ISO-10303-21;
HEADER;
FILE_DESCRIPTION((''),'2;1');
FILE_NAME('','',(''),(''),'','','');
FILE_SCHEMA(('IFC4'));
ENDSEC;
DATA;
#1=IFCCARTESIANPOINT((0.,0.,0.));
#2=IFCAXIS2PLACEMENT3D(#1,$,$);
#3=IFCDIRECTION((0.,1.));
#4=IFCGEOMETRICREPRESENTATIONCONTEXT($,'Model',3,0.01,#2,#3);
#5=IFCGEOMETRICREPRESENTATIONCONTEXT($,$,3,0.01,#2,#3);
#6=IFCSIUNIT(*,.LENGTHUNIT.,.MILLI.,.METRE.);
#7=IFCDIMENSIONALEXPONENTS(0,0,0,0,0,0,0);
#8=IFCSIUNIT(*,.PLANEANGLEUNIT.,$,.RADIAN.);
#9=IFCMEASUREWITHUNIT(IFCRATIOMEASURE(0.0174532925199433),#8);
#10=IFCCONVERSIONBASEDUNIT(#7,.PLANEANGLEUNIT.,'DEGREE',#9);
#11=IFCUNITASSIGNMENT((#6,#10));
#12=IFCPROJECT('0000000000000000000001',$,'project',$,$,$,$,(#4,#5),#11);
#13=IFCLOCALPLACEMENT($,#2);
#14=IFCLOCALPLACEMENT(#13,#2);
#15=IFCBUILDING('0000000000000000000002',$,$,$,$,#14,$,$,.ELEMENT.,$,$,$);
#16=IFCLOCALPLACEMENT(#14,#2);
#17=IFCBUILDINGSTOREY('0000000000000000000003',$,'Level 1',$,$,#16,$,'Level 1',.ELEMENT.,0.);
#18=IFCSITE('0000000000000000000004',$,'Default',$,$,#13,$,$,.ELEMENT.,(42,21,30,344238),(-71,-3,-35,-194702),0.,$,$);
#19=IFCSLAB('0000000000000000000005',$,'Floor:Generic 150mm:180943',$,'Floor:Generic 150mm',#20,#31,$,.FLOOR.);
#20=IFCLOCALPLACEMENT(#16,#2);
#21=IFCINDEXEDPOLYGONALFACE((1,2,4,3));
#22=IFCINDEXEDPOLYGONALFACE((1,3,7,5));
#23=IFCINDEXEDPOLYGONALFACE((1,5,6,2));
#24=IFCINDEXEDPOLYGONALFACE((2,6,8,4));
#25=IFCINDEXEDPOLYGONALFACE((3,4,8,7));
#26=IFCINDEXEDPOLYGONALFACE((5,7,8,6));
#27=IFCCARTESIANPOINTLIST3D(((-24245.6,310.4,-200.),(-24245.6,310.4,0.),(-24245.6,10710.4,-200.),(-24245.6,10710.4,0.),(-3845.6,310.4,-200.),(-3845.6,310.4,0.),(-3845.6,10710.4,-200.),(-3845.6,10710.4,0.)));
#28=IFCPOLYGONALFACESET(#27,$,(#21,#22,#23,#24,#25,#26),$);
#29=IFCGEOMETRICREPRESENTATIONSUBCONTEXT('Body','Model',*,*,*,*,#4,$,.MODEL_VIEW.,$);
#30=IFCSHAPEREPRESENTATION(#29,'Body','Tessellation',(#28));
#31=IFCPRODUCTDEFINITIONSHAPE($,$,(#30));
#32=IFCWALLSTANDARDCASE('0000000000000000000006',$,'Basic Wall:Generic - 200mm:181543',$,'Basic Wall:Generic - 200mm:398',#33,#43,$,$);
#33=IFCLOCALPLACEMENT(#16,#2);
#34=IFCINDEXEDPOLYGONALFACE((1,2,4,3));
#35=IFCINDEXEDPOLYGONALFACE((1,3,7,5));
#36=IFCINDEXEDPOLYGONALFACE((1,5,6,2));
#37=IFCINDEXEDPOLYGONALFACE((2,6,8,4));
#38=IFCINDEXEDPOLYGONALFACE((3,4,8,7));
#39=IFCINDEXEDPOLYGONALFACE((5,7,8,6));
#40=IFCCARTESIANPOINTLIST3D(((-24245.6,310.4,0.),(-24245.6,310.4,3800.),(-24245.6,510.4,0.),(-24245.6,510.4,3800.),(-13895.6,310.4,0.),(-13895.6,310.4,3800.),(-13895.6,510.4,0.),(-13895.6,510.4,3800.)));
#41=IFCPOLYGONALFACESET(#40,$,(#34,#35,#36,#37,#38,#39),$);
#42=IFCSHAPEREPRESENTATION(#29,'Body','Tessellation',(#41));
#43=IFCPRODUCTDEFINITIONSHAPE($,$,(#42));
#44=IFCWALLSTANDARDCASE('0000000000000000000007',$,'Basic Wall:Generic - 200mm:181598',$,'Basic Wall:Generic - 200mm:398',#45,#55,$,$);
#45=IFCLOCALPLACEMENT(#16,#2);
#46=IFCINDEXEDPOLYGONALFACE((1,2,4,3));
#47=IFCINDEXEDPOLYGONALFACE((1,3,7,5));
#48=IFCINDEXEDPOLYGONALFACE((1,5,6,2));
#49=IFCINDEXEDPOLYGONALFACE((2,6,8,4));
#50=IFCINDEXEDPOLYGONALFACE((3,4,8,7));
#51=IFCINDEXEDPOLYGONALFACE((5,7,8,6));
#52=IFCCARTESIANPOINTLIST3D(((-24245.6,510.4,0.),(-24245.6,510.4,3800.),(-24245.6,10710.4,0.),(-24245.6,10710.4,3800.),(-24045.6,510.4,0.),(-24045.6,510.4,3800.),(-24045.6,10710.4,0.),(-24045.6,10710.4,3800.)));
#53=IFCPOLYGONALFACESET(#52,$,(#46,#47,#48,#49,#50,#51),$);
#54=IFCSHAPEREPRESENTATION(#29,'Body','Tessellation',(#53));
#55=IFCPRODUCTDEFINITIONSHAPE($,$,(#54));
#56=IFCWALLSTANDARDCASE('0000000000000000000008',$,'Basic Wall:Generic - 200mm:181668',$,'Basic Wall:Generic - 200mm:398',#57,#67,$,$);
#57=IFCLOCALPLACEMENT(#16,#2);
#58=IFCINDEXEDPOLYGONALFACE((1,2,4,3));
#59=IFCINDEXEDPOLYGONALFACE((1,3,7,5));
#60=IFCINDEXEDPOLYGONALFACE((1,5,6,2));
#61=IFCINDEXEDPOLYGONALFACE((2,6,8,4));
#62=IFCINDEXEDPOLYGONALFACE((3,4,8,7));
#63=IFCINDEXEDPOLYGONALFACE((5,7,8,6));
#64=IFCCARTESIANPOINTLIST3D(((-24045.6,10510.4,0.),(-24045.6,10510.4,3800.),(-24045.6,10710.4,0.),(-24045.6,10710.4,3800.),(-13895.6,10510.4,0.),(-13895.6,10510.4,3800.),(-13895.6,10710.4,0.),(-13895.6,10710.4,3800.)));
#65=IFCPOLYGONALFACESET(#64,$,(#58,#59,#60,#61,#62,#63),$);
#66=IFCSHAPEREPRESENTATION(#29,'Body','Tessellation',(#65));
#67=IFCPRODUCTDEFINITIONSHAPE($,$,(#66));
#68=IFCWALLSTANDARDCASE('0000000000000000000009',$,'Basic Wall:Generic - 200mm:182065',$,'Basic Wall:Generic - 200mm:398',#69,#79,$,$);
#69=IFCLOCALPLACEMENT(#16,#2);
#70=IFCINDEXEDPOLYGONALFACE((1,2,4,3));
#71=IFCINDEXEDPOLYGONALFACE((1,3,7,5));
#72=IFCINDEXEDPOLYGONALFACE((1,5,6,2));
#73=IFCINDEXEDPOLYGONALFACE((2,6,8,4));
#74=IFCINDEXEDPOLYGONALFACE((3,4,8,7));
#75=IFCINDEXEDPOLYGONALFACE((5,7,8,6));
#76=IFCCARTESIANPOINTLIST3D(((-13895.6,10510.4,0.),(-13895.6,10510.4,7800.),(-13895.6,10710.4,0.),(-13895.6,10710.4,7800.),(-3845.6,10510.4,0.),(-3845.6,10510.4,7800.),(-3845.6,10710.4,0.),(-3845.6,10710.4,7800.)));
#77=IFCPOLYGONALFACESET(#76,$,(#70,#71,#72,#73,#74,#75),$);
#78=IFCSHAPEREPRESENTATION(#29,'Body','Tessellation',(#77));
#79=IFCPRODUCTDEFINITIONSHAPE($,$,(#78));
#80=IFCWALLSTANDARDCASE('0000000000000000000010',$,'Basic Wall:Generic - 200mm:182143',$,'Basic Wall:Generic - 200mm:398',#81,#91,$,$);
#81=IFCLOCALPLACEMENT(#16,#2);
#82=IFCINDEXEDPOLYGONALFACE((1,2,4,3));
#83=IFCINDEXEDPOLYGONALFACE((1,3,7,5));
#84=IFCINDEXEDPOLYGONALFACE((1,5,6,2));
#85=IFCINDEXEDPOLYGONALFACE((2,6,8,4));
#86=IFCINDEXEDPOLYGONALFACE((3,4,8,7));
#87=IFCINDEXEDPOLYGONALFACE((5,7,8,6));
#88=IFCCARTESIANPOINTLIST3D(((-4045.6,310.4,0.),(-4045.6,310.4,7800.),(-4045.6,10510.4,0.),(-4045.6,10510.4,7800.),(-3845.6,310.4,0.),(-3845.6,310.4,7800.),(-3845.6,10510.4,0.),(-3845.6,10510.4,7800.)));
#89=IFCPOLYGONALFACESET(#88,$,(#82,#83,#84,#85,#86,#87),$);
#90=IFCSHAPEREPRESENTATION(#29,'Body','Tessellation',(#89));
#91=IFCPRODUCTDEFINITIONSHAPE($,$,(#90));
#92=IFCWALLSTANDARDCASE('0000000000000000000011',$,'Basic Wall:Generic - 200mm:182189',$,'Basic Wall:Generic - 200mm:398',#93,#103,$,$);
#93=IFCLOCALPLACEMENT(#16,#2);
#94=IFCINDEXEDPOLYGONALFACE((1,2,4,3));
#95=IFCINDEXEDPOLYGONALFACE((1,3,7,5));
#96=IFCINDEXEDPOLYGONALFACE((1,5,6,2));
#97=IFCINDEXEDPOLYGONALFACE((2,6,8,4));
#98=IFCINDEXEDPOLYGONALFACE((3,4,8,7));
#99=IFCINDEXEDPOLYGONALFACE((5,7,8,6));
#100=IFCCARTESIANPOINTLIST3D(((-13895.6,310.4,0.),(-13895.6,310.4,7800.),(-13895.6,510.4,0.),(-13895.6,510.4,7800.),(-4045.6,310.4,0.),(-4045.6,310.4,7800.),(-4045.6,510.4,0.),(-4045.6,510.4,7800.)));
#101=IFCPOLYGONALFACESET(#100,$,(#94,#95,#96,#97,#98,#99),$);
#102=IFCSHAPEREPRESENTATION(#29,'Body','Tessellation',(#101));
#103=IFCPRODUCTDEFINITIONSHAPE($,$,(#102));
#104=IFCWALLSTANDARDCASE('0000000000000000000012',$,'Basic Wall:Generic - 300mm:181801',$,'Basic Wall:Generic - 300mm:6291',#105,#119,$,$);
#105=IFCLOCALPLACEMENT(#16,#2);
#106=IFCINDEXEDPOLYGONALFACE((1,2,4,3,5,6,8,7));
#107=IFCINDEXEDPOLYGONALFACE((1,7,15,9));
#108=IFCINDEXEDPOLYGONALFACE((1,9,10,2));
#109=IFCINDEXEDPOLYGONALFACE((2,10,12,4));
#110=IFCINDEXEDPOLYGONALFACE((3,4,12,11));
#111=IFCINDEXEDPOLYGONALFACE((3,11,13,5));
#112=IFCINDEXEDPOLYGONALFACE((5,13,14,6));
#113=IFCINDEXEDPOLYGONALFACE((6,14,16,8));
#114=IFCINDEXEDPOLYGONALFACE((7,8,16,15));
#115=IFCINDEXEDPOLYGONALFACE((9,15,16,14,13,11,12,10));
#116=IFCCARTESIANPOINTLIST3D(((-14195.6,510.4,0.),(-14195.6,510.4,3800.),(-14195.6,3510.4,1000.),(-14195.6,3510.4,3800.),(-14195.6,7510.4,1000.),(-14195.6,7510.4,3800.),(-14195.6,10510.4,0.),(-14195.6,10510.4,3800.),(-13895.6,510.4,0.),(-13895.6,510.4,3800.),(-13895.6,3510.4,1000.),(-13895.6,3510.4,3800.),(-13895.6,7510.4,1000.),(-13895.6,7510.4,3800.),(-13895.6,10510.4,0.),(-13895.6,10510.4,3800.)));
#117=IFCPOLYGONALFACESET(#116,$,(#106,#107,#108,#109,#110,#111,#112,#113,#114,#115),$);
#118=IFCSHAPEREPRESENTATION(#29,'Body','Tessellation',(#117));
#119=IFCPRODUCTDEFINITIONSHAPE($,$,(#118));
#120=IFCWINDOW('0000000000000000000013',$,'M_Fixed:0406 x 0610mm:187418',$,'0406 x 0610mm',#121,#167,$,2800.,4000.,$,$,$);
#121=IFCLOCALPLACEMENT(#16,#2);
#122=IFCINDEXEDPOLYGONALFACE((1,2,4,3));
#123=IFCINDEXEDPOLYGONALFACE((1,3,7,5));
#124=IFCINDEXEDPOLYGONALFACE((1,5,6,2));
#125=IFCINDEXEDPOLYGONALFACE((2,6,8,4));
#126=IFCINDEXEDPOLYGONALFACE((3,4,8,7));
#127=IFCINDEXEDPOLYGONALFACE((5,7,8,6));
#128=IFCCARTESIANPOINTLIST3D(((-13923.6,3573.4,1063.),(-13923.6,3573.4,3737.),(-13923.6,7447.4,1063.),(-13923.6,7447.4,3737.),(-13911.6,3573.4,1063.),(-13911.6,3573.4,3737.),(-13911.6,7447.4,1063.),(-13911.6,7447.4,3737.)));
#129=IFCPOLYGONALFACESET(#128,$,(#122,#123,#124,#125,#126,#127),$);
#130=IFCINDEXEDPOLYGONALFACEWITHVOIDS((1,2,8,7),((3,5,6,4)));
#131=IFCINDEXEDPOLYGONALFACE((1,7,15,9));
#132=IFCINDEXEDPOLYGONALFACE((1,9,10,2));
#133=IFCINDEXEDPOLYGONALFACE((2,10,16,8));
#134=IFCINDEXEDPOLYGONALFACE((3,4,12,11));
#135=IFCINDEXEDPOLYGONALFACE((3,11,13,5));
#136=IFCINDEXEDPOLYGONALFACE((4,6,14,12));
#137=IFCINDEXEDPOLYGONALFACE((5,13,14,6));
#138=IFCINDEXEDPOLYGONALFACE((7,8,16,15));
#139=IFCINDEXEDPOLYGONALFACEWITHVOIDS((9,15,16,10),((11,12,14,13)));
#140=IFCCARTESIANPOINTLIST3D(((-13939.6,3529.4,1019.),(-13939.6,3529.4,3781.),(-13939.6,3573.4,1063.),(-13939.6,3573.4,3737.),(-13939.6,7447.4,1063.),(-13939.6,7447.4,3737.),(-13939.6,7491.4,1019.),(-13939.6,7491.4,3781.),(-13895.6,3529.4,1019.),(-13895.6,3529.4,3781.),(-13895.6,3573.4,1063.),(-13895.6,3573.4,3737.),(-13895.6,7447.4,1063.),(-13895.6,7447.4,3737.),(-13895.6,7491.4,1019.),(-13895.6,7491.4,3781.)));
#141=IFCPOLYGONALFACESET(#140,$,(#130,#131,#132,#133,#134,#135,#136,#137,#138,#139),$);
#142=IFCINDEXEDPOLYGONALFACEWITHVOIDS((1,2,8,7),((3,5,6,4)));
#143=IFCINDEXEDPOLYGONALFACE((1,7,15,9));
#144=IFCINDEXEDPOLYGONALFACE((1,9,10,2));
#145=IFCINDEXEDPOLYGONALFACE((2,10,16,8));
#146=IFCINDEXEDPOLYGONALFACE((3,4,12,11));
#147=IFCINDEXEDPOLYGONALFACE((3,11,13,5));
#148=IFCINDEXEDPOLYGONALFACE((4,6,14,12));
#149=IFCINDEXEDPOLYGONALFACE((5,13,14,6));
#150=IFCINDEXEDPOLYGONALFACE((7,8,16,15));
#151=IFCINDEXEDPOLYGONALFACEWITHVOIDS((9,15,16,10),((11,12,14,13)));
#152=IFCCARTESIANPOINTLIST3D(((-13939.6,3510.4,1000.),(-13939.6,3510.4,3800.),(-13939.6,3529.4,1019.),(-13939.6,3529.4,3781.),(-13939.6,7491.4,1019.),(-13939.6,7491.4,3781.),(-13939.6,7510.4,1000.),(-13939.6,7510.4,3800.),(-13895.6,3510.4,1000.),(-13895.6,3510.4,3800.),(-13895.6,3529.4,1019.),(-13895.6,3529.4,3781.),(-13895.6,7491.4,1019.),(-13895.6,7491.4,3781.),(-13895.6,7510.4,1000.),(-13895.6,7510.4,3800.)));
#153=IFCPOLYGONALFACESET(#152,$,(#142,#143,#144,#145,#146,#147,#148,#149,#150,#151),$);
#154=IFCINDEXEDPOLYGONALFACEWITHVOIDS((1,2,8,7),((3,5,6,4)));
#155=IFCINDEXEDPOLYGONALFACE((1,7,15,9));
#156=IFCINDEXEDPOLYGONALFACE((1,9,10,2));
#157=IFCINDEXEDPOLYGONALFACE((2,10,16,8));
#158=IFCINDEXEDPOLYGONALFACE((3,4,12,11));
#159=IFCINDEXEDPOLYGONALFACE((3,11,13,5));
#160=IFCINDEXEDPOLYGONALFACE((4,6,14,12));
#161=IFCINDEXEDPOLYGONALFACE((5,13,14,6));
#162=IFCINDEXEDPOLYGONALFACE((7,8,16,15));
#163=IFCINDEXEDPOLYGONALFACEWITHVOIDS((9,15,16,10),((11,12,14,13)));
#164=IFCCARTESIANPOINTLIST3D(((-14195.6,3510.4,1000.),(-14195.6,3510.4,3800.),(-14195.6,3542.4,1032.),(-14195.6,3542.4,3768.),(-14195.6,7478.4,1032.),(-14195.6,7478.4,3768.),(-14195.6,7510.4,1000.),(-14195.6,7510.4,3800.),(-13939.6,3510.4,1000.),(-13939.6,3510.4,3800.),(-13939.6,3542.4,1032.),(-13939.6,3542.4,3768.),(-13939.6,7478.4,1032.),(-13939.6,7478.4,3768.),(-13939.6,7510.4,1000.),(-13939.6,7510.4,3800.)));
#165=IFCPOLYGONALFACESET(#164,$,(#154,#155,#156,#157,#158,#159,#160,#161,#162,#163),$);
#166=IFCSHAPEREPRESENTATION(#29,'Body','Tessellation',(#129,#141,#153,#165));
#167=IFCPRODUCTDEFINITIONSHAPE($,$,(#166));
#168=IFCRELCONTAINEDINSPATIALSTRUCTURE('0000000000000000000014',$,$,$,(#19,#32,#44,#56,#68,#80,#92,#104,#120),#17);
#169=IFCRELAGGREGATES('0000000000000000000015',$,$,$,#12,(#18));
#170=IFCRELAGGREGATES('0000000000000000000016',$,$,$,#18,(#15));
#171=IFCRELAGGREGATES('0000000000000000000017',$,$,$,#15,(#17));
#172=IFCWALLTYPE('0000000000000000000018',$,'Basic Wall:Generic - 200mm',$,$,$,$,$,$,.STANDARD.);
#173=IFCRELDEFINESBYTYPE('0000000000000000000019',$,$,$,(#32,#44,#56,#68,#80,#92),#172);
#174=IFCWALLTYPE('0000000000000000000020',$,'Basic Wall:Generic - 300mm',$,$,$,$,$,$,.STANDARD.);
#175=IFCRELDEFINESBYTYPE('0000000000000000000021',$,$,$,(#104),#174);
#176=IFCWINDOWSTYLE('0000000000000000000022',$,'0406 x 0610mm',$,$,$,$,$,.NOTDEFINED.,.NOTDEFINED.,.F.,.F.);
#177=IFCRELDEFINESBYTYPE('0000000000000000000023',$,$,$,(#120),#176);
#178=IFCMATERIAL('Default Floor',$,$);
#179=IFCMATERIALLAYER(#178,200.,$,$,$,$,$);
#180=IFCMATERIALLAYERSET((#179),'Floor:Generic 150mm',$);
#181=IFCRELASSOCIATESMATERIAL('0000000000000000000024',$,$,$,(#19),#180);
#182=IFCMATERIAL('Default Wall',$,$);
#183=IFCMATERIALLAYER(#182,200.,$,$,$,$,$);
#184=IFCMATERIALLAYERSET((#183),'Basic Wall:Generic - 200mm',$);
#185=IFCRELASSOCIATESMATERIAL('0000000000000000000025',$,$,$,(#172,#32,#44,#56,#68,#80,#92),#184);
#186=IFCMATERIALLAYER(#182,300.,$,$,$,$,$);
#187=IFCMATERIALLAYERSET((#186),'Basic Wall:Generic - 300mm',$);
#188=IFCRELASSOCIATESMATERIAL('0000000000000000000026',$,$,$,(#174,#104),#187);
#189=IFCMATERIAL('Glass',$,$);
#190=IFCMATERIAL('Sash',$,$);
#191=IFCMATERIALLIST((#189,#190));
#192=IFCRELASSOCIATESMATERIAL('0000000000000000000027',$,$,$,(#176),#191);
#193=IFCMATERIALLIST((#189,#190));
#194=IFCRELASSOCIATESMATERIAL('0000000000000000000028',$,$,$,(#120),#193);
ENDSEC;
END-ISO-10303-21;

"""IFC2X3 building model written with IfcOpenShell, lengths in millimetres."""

from ifc_helpers import new_model, entity, si_unit, converted_unit, direction, frame, frame_2d, origin, origin_2d_with_axis, place, context, subcontext, project, spatial, polyline, rectangle, outline, extrude, source, transform, mapped, material, material_list, layer, layer_set, layer_usage, type_object, type_shapes, element, fill, save


model = new_model("IFC2X3")

# Units and contexts
model_context = context("Model", 3, precision=0.01, world=origin(), true_north=direction((0.0, 1.0)))
context_of_model = context(None, 3, precision=0.01, world=origin(), true_north=direction((0.0, 1.0)))
body_context = subcontext(model_context, "Body", "Model", "MODEL_VIEW")
ifc_project = project(units=[si_unit("LENGTHUNIT", "METRE", prefix="MILLI"), converted_unit("PLANEANGLEUNIT", "DEGREE", entity("IfcRatioMeasure", 0.0174532925199433), si_unit("PLANEANGLEUNIT", "RADIAN"), dimensions=[0, 0, 0, 0, 0, 0, 0])], contexts=[model_context, context_of_model])

# Site, building, storey
site_placement = place(None, origin())
site = spatial("IfcSite", under=ifc_project, at=site_placement, Name="Default", CompositionType="ELEMENT", RefLatitude=(42, 21, 30, 344238), RefLongitude=(-71, -3, -35, -194702), RefElevation=0.0)
building_placement = place(site_placement, origin())
building = spatial("IfcBuilding", under=site, at=building_placement, CompositionType="ELEMENT")
storey_placement = place(building_placement, origin())
storey = spatial("IfcBuildingStorey", under=building, at=storey_placement, Name="Level 1", LongName="Level 1", CompositionType="ELEMENT", Elevation=0.0)

# Slab
ifc_material_1 = material(Name="Default Floor")
ifc_layer_1 = layer(ifc_material_1, 200.0)
ifc_layer_set_1 = layer_set([ifc_layer_1], Name="Floor:Generic 150mm")
ifc_layer_usage_1 = layer_usage(ifc_layer_set_1, "AXIS3", "POSITIVE", 0.0)
slab_placement = place(storey_placement, origin())
element("IfcSlab", 1, at=slab_placement, inside=storey, material=ifc_layer_usage_1, Name="Floor:Generic 150mm:180943", ObjectType="Floor:Generic 150mm", PredefinedType="FLOOR", context=body_context, shape_type="SweptSolid", body=[
    extrude(rectangle(XDim=10400.0, YDim=20400.0, at=origin_2d_with_axis()), frame((-14045.6, 5510.4, 0.0), z_axis=(0.0, 0.0, -1.0), x_axis=(0.0, 1.0, 0.0)), (0.0, 0.0, 1.0), 200.0),
])

# Walls
ifc_material_2 = material(Name="Default Wall")
ifc_layer_2 = layer(ifc_material_2, 200.0)
ifc_layer_set_2 = layer_set([ifc_layer_2], Name="Basic Wall:Generic - 200mm")
ifc_layer_usage_2 = layer_usage(ifc_layer_set_2, "AXIS2", "NEGATIVE", 100.0)
wall_type_1 = type_object("IfcWallType", Name="Basic Wall:Generic - 200mm", PredefinedType="STANDARD", material=ifc_layer_set_2)
wall_1_placement = place(storey_placement, frame((-13895.6, 410.4, 0.0), z_axis=(0.0, 0.0, 1.0), x_axis=(-1.0, 0.0, 0.0)))
element("IfcWallStandardCase", 2, at=wall_1_placement, inside=storey, type_object=wall_type_1, material=ifc_layer_usage_2, Name="Basic Wall:Generic - 200mm:181543", ObjectType="Basic Wall:Generic - 200mm:398", context=body_context, shape_type="SweptSolid", body=[
    extrude(rectangle(XDim=10350.0, YDim=200.0, at=frame_2d((5175.0, 0.0), x_axis=(-1.0, 0.0))), origin(), (0.0, 0.0, 1.0), 3800.0),
])
ifc_layer_usage_3 = layer_usage(ifc_layer_set_2, "AXIS2", "NEGATIVE", 100.0)
wall_2_placement = place(storey_placement, frame((-24145.6, 510.4, 0.0), z_axis=(0.0, 0.0, 1.0), x_axis=(0.0, 1.0, 0.0)))
element("IfcWallStandardCase", 3, at=wall_2_placement, inside=storey, type_object=wall_type_1, material=ifc_layer_usage_3, Name="Basic Wall:Generic - 200mm:181598", ObjectType="Basic Wall:Generic - 200mm:398", context=body_context, shape_type="SweptSolid", body=[
    extrude(rectangle(XDim=10200.0, YDim=200.0, at=frame_2d((5100.0, 0.0), x_axis=(-1.0, 0.0))), origin(), (0.0, 0.0, 1.0), 3800.0),
])
ifc_layer_usage_4 = layer_usage(ifc_layer_set_2, "AXIS2", "NEGATIVE", 100.0)
wall_3_placement = place(storey_placement, frame((-24045.6, 10610.4, 0.0)))
element("IfcWallStandardCase", 4, at=wall_3_placement, inside=storey, type_object=wall_type_1, material=ifc_layer_usage_4, Name="Basic Wall:Generic - 200mm:181668", ObjectType="Basic Wall:Generic - 200mm:398", context=body_context, shape_type="SweptSolid", body=[
    extrude(rectangle(XDim=10150.0, YDim=200.0, at=frame_2d((5075.0, 0.0), x_axis=(-1.0, 0.0))), origin(), (0.0, 0.0, 1.0), 3800.0),
])
ifc_layer_usage_5 = layer_usage(ifc_layer_set_2, "AXIS2", "NEGATIVE", 100.0)
wall_4_placement = place(storey_placement, frame((-13895.6, 10610.4, 0.0)))
element("IfcWallStandardCase", 5, at=wall_4_placement, inside=storey, type_object=wall_type_1, material=ifc_layer_usage_5, Name="Basic Wall:Generic - 200mm:182065", ObjectType="Basic Wall:Generic - 200mm:398", context=body_context, shape_type="SweptSolid", body=[
    extrude(rectangle(XDim=10050.0, YDim=200.0, at=frame_2d((5025.0, 0.0), x_axis=(-1.0, 0.0))), origin(), (0.0, 0.0, 1.0), 7800.0),
])
ifc_layer_usage_6 = layer_usage(ifc_layer_set_2, "AXIS2", "NEGATIVE", 100.0)
wall_5_placement = place(storey_placement, frame((-3945.6, 10510.4, 0.0), z_axis=(0.0, 0.0, 1.0), x_axis=(0.0, -1.0, 0.0)))
element("IfcWallStandardCase", 6, at=wall_5_placement, inside=storey, type_object=wall_type_1, material=ifc_layer_usage_6, Name="Basic Wall:Generic - 200mm:182143", ObjectType="Basic Wall:Generic - 200mm:398", context=body_context, shape_type="SweptSolid", body=[
    extrude(rectangle(XDim=10200.0, YDim=200.0, at=frame_2d((5100.0, 0.0), x_axis=(-1.0, 0.0))), origin(), (0.0, 0.0, 1.0), 7800.0),
])
ifc_layer_usage_7 = layer_usage(ifc_layer_set_2, "AXIS2", "NEGATIVE", 100.0)
wall_6_placement = place(storey_placement, frame((-4045.6, 410.4, 0.0), z_axis=(0.0, 0.0, 1.0), x_axis=(-1.0, 0.0, 0.0)))
element("IfcWallStandardCase", 7, at=wall_6_placement, inside=storey, type_object=wall_type_1, material=ifc_layer_usage_7, Name="Basic Wall:Generic - 200mm:182189", ObjectType="Basic Wall:Generic - 200mm:398", context=body_context, shape_type="SweptSolid", body=[
    extrude(rectangle(XDim=9850.0, YDim=200.0, at=frame_2d((4925.0, 0.0), x_axis=(-1.0, 0.0))), origin(), (0.0, 0.0, 1.0), 7800.0),
])

# Wall, opening, window
ifc_layer_3 = layer(ifc_material_2, 300.0)
ifc_layer_set_3 = layer_set([ifc_layer_3], Name="Basic Wall:Generic - 300mm")
ifc_layer_usage_8 = layer_usage(ifc_layer_set_3, "AXIS2", "NEGATIVE", 150.0)
wall_type_2 = type_object("IfcWallType", Name="Basic Wall:Generic - 300mm", PredefinedType="STANDARD", material=ifc_layer_set_3)
wall_7_placement = place(storey_placement, frame((-14045.6, 10510.4, 0.0), z_axis=(0.0, 0.0, 1.0), x_axis=(0.0, -1.0, 0.0)))
wall_7 = element("IfcWallStandardCase", 8, at=wall_7_placement, inside=storey, type_object=wall_type_2, material=ifc_layer_usage_8, Name="Basic Wall:Generic - 300mm:181801", ObjectType="Basic Wall:Generic - 300mm:6291", context=body_context, shape_type="SweptSolid", body=[
    extrude(rectangle(XDim=10000.0, YDim=300.0, at=frame_2d((5000.0, 0.0), x_axis=(-1.0, 0.0))), origin(), (0.0, 0.0, 1.0), 3800.0),
])
opening_placement = place(wall_7_placement, frame((3000.0, -150.0, 1000.0)))
opening = element("IfcOpeningElement", 9, at=opening_placement, cuts=wall_7, ObjectType="Opening", context=body_context, shape_type="SweptSolid", body=[
    extrude(rectangle(XDim=2800.0, YDim=4000.0, at=frame_2d((1400.0, 2000.0), x_axis=(1.0, 0.0))), frame((0.0, 0.0, 0.0), z_axis=(0.0, 1.0, 0.0), x_axis=(0.0, 0.0, 1.0)), (0.0, 0.0, 1.0), 300.0),
])
ifc_material_3 = material(Name="Glass")
ifc_material_4 = material(Name="Sash")
ifc_material_list_1 = material_list([ifc_material_3, ifc_material_4])
ifc_material_list_2 = material_list([ifc_material_3, ifc_material_4])
window_style = type_object("IfcWindowStyle", Name="0406 x 0610mm", ConstructionType="NOTDEFINED", OperationType="NOTDEFINED", ParameterTakesPrecedence=False, Sizeable=False, material=ifc_material_list_2)
shared_shape = source(origin(), body_context, "Body", "SweptSolid", [
    extrude(rectangle(XDim=12.0, YDim=3874.0, at=frame_2d((0.0, 0.0), x_axis=(1.0, 0.0))), frame((2000.0, 278.0, 63.0), z_axis=(0.0, 0.0, 1.0), x_axis=(0.0, -1.0, 0.0)), (0.0, 0.0, 1.0), 2674.0),
    extrude(outline(polyline([(-1981.0, -1381.0), (1981.0, -1381.0), (1981.0, 1381.0), (-1981.0, 1381.0), (-1981.0, -1381.0)]), holes=[polyline([(-1937.0, -1337.0), (-1937.0, 1337.0), (1937.0, 1337.0), (1937.0, -1337.0), (-1937.0, -1337.0)])]), frame((2000.0, 256.0, 1400.0), z_axis=(0.0, 1.0, 0.0), x_axis=(1.0, 0.0, 0.0)), (0.0, 0.0, 1.0), 44.0),
    extrude(outline(polyline([(-2000.0, -1400.0), (2000.0, -1400.0), (2000.0, 1400.0), (-2000.0, 1400.0), (-2000.0, -1400.0)]), holes=[polyline([(-1981.0, -1381.0), (-1981.0, 1381.0), (1981.0, 1381.0), (1981.0, -1381.0), (-1981.0, -1381.0)])]), frame((2000.0, 256.0, 1400.0), z_axis=(0.0, 1.0, 0.0), x_axis=(1.0, 0.0, 0.0)), (0.0, 0.0, 1.0), 44.0),
    extrude(outline(polyline([(-2000.0, -1400.0), (2000.0, -1400.0), (2000.0, 1400.0), (-2000.0, 1400.0), (-2000.0, -1400.0)]), holes=[polyline([(-1968.0, -1368.0), (-1968.0, 1368.0), (1968.0, 1368.0), (1968.0, -1368.0), (-1968.0, -1368.0)])]), frame((2000.0, 0.0, 1400.0), z_axis=(0.0, 1.0, 0.0), x_axis=(1.0, 0.0, 0.0)), (0.0, 0.0, 1.0), 256.0),
])
type_shapes(window_style, [shared_shape])
window_placement = place(opening_placement, origin())
window = element("IfcWindow", 10, at=window_placement, inside=storey, type_object=window_style, material=ifc_material_list_1, Name="M_Fixed:0406 x 0610mm:187418", ObjectType="0406 x 0610mm", OverallHeight=2800.0, OverallWidth=4000.0, context=body_context, shape_type="MappedRepresentation", body=[
    mapped(shared_shape, transform((0.0, 0.0, 0.0), scale=1.0)),
])
fill(opening, window)

save(model, "model.ifc")
